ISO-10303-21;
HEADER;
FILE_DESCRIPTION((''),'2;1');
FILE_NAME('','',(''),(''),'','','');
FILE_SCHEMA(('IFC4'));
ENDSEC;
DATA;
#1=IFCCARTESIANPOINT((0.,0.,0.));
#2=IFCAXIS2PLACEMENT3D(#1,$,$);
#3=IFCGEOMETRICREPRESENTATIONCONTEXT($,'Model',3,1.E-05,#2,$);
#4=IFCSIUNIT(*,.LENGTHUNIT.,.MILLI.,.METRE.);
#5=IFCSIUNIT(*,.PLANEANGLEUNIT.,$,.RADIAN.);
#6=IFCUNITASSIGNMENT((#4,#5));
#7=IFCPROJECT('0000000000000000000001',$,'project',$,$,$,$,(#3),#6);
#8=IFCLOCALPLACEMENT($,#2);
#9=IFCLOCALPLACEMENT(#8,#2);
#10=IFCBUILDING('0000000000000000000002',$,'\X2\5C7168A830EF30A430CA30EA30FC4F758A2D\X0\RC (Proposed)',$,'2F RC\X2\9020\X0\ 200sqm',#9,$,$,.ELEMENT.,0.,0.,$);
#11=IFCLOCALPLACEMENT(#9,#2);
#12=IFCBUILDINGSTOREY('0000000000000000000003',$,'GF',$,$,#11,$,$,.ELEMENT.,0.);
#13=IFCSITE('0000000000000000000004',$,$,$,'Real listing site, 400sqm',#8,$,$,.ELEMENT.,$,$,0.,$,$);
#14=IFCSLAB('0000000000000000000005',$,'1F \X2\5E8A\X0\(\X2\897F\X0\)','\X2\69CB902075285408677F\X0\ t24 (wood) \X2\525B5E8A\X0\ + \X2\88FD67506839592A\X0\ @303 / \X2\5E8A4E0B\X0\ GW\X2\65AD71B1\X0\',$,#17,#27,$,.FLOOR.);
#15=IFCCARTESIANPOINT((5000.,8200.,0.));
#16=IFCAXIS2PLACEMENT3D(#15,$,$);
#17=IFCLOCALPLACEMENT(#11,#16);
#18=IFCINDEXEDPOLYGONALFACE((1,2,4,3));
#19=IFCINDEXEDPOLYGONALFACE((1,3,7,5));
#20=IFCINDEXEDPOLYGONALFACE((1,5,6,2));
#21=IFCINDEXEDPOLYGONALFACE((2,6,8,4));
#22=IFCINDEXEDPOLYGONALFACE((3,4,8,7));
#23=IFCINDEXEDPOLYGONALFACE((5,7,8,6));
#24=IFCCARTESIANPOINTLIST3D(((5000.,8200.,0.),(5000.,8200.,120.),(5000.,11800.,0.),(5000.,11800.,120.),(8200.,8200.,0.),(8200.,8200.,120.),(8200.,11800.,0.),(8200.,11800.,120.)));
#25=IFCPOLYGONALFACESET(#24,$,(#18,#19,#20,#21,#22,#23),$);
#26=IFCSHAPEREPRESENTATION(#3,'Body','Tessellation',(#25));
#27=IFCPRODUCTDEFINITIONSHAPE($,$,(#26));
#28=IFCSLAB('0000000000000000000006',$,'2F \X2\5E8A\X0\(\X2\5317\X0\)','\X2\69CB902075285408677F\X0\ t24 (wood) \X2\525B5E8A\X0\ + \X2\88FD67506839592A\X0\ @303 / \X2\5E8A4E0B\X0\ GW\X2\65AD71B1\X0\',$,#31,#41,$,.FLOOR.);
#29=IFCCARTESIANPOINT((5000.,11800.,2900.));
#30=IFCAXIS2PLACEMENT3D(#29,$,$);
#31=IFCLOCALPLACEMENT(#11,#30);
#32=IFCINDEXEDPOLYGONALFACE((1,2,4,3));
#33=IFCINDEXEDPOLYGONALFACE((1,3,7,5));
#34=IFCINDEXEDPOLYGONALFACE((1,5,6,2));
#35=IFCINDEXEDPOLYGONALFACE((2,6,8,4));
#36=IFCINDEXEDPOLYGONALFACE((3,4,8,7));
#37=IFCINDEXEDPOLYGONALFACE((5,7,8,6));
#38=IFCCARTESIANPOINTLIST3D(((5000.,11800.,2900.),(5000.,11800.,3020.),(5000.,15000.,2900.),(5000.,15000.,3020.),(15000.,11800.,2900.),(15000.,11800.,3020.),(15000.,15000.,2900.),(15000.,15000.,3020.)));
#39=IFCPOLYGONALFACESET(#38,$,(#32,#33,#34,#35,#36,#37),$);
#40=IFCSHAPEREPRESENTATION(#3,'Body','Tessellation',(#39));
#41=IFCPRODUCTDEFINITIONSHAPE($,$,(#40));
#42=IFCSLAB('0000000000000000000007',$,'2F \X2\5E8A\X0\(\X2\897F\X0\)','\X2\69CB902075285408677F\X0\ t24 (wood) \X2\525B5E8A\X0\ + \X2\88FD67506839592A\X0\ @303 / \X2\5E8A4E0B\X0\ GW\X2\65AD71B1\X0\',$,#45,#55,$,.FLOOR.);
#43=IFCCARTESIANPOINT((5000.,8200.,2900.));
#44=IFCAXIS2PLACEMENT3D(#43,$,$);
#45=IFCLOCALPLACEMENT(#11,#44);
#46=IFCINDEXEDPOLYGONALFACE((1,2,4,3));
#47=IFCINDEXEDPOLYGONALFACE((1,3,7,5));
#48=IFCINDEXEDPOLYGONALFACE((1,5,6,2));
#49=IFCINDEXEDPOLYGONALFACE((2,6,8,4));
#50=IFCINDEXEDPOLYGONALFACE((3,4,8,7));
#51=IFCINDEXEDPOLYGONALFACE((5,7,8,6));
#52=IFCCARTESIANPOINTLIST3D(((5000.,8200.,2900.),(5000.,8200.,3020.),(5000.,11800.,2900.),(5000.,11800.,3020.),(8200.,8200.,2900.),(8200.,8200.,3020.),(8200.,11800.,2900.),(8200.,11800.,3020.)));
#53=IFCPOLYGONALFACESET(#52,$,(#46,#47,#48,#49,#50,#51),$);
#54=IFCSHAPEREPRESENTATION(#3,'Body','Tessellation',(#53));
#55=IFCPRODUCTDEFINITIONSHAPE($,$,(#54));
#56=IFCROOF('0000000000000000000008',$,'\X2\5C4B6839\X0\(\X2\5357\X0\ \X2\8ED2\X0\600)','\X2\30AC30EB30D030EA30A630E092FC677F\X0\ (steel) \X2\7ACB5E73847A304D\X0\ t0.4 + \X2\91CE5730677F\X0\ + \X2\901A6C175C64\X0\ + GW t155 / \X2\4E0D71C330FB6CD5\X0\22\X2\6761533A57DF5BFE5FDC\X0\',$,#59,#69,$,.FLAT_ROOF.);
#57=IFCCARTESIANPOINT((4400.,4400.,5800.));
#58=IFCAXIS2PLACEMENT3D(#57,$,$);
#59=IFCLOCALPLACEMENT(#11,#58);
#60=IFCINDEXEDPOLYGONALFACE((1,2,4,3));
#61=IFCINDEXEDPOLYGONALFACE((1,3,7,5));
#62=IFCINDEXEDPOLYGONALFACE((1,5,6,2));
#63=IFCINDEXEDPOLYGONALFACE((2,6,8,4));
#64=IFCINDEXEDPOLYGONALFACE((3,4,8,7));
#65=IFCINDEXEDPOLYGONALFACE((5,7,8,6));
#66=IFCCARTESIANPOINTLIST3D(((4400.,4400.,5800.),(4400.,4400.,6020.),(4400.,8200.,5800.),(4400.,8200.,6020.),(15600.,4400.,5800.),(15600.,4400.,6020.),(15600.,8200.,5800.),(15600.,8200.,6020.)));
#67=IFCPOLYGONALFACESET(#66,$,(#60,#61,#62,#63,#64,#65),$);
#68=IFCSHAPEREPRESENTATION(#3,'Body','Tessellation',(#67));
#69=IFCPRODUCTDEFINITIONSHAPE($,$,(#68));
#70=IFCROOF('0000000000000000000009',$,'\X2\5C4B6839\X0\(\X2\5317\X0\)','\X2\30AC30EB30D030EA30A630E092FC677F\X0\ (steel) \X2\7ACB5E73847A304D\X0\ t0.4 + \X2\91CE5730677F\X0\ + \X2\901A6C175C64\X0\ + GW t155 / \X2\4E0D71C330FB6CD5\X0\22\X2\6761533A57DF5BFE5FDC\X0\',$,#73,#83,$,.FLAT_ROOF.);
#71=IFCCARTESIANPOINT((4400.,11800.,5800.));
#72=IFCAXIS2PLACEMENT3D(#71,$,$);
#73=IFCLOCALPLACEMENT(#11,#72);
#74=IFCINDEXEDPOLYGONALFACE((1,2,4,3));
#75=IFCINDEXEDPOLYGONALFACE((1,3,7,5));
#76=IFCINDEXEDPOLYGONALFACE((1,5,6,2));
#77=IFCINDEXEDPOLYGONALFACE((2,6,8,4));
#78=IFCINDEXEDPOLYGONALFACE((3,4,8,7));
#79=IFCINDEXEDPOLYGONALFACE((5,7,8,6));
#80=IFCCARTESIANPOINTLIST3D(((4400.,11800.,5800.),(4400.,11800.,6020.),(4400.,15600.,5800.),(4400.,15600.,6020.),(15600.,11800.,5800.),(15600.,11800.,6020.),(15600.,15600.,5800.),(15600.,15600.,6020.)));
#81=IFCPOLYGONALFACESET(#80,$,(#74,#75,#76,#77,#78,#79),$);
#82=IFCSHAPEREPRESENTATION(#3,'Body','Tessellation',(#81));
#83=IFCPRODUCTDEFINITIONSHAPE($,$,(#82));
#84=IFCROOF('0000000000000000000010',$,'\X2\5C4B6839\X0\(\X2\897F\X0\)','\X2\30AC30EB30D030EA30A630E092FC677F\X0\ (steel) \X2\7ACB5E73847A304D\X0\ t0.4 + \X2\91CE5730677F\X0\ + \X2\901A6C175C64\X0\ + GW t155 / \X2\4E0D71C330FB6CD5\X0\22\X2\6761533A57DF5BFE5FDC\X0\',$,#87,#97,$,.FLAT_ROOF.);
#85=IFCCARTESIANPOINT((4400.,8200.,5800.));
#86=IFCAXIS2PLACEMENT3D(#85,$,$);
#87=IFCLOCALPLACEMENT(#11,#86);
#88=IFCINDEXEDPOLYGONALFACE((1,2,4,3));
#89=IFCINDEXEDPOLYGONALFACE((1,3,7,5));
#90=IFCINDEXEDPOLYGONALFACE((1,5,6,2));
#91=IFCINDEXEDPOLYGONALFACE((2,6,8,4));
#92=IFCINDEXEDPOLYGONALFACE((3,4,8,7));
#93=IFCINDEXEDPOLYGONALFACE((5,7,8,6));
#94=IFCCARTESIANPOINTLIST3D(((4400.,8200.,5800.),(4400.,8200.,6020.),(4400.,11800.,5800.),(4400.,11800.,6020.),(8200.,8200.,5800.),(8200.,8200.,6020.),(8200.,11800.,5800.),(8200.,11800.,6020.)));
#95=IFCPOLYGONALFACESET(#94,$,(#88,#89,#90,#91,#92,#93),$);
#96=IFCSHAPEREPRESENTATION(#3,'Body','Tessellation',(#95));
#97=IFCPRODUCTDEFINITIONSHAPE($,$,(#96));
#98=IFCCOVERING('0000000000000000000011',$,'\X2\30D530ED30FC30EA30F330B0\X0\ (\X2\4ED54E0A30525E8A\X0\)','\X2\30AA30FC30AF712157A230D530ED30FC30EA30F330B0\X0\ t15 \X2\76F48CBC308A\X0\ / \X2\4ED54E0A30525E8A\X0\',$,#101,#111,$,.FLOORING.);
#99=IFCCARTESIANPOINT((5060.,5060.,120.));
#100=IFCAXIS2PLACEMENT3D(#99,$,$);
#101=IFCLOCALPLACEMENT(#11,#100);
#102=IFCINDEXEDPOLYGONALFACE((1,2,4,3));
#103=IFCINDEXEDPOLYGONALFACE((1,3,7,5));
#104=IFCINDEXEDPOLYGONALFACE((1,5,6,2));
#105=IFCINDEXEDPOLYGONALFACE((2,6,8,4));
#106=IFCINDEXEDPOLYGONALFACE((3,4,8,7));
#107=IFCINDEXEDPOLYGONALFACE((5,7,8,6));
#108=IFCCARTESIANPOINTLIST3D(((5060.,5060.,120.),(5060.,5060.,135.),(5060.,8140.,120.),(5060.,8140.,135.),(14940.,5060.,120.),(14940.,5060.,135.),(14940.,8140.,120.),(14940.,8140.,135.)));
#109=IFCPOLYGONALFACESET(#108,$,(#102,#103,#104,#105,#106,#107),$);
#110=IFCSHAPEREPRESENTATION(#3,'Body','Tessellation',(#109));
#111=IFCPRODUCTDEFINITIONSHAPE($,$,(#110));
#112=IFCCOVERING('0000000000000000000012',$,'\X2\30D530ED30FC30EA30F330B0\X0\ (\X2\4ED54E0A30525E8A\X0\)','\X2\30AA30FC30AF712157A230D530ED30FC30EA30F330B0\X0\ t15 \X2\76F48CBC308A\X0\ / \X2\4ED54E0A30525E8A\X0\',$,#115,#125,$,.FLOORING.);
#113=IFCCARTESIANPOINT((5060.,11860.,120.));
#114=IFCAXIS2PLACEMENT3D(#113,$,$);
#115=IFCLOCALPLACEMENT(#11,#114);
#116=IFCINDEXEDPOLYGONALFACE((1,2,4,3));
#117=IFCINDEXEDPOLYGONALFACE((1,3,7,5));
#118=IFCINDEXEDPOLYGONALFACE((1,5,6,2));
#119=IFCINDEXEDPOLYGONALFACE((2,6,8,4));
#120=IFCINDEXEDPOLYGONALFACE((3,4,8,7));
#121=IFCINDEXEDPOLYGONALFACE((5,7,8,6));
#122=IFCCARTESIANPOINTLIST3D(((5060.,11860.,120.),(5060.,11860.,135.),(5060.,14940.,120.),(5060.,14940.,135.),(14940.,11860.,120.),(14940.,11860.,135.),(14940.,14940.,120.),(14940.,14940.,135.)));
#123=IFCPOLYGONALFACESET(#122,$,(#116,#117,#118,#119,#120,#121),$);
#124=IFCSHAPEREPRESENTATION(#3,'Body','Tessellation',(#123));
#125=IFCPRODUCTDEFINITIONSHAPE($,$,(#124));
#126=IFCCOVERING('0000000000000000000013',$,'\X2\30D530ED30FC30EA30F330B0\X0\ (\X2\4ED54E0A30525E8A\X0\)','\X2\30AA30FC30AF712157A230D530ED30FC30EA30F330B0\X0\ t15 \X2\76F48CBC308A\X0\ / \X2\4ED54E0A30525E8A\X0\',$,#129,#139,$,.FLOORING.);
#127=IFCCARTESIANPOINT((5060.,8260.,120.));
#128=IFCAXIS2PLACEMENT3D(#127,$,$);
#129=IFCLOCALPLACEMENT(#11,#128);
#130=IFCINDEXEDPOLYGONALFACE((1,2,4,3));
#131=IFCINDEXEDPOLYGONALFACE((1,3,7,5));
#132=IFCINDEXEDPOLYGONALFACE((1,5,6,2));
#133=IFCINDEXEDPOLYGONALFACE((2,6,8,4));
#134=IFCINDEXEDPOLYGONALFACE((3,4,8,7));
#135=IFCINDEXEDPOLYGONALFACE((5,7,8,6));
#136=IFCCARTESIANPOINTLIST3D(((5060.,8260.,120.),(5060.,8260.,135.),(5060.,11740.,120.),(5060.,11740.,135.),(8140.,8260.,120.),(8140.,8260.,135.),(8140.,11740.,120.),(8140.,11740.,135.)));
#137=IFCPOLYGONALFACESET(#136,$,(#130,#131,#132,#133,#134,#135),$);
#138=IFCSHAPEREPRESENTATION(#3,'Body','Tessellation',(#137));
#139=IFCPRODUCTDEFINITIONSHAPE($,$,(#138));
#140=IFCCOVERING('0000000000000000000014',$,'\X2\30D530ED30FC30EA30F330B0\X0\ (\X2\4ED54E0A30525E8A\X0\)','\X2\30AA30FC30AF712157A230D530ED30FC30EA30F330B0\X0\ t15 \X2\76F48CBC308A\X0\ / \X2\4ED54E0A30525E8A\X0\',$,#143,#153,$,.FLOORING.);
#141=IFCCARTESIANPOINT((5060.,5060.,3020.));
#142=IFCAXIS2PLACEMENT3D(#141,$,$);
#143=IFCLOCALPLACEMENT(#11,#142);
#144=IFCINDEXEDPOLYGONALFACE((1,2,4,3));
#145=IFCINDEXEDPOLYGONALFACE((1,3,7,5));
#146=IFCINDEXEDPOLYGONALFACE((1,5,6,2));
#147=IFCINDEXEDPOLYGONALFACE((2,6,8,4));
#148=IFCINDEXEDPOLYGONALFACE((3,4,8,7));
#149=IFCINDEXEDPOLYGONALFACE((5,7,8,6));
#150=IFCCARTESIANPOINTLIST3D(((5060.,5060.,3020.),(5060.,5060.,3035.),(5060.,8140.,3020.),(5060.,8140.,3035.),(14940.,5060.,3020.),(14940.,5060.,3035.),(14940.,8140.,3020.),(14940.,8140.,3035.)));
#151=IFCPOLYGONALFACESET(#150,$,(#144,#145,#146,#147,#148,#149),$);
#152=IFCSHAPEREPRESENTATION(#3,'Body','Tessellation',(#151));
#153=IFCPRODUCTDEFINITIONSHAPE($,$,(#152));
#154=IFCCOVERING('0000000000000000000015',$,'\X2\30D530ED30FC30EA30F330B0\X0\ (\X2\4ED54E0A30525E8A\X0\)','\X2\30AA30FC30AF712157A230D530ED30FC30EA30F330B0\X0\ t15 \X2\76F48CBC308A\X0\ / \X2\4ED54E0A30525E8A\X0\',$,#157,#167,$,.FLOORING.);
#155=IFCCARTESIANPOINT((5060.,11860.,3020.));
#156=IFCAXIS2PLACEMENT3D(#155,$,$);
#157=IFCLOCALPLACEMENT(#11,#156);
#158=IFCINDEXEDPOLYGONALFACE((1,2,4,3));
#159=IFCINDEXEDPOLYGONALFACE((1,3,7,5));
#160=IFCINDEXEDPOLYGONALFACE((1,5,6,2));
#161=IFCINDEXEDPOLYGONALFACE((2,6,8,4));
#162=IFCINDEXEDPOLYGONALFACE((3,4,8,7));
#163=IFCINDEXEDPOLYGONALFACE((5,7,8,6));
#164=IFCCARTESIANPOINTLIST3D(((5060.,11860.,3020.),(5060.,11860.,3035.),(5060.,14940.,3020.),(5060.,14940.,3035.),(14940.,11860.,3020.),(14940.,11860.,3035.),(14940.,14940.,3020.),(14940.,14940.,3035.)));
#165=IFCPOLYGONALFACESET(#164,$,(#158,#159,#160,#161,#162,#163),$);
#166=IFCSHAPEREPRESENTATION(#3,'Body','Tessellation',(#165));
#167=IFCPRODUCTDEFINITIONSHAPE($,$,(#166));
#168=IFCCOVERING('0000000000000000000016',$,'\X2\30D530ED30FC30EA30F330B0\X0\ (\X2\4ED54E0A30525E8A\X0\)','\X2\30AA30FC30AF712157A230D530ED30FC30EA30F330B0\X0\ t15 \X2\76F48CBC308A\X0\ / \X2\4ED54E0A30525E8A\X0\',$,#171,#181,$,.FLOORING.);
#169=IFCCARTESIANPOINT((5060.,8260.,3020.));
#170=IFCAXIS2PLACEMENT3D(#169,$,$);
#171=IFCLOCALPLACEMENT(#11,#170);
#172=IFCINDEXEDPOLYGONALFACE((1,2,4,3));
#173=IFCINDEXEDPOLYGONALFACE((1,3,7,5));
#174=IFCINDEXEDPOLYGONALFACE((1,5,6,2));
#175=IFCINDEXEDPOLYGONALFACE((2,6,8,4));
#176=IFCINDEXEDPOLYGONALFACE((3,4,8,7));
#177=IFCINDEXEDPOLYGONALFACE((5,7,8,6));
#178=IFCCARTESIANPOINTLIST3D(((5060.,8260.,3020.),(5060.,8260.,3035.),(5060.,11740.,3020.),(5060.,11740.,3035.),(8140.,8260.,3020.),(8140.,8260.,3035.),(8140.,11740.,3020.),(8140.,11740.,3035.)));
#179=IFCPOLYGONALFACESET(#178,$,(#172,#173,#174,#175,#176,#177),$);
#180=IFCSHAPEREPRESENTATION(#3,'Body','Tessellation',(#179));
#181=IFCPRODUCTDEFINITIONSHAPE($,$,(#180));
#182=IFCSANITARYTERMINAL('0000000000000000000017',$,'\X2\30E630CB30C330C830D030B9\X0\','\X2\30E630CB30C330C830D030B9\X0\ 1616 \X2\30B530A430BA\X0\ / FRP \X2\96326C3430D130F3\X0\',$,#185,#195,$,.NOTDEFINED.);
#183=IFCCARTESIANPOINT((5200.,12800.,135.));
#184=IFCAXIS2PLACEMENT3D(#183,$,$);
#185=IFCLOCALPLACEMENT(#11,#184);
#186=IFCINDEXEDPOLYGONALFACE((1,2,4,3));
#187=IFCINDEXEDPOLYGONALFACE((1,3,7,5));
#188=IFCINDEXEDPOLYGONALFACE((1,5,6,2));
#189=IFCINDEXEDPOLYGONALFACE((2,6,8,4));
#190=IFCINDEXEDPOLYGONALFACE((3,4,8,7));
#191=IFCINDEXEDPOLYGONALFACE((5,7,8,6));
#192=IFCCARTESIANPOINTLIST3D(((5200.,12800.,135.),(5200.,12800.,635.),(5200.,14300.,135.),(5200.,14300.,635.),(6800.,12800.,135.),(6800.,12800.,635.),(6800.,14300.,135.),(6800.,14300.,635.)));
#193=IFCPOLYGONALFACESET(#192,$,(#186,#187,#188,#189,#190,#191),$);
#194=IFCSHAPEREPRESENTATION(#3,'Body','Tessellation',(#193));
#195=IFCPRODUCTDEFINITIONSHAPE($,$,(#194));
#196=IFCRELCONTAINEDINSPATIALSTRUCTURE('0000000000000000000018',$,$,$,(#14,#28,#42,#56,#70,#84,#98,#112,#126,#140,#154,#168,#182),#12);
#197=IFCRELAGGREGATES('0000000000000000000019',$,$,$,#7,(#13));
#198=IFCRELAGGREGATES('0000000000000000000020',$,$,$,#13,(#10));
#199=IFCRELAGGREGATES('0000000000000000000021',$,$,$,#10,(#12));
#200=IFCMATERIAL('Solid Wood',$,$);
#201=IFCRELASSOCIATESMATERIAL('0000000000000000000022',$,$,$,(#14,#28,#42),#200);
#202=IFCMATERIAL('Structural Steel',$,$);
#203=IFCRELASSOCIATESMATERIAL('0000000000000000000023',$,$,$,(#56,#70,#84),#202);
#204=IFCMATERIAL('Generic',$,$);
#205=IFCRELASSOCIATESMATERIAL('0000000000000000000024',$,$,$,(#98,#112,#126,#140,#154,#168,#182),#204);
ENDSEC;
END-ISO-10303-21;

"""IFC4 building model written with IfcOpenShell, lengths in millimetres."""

from ifc_helpers import new_model, si_unit, frame, frame_2d, origin, place, context, project, spatial, rectangle, extrude, material, element, save


model = new_model("IFC4")

# Units and contexts
model_context = context("Model", 3, precision=1e-05, world=origin())
ifc_project = project(units=[si_unit("LENGTHUNIT", "METRE", prefix="MILLI"), si_unit("PLANEANGLEUNIT", "RADIAN")], contexts=[model_context])

# Site, building, storey
site_placement = place(None, origin())
site = spatial("IfcSite", under=ifc_project, at=site_placement, ObjectType="Real listing site, 400sqm", CompositionType="ELEMENT", RefElevation=0.0)
building_placement = place(site_placement, origin())
building = spatial("IfcBuilding", under=site, at=building_placement, Name="山梨ワイナリー併設RC (Proposed)", ObjectType="2F RC造 200sqm", CompositionType="ELEMENT", ElevationOfRefHeight=0.0, ElevationOfTerrain=0.0)
storey_placement = place(building_placement, origin())
storey = spatial("IfcBuildingStorey", under=building, at=storey_placement, Name="GF", CompositionType="ELEMENT", Elevation=0.0)

# Slabs
ifc_material_1 = material(Name="Solid Wood")
slab_1_placement = place(storey_placement, frame((5000.0, 8200.0, 0.0)))
element("IfcSlab", 1, at=slab_1_placement, inside=storey, material=ifc_material_1, Name="1F 床(西)", Description="構造用合板 t24 (wood) 剛床 + 製材根太 @303 / 床下 GW断熱", PredefinedType="FLOOR", context=model_context, shape_type="SweptSolid", body=[
    extrude(rectangle(XDim=3200.0, YDim=3600.0, at=frame_2d((1600.0, 1800.0))), frame((5000.0, 8200.0, 0.0)), (0.0, 0.0, 1.0), 120.0),
])
slab_2_placement = place(storey_placement, frame((5000.0, 11800.0, 2900.0)))
element("IfcSlab", 2, at=slab_2_placement, inside=storey, material=ifc_material_1, Name="2F 床(北)", Description="構造用合板 t24 (wood) 剛床 + 製材根太 @303 / 床下 GW断熱", PredefinedType="FLOOR", context=model_context, shape_type="SweptSolid", body=[
    extrude(rectangle(XDim=10000.0, YDim=3200.0, at=frame_2d((5000.0, 1600.0))), frame((5000.0, 11800.0, 2900.0)), (0.0, 0.0, 1.0), 120.0),
])
slab_3_placement = place(storey_placement, frame((5000.0, 8200.0, 2900.0)))
element("IfcSlab", 3, at=slab_3_placement, inside=storey, material=ifc_material_1, Name="2F 床(西)", Description="構造用合板 t24 (wood) 剛床 + 製材根太 @303 / 床下 GW断熱", PredefinedType="FLOOR", context=model_context, shape_type="SweptSolid", body=[
    extrude(rectangle(XDim=3200.0, YDim=3600.0, at=frame_2d((1600.0, 1800.0))), frame((5000.0, 8200.0, 2900.0)), (0.0, 0.0, 1.0), 120.0),
])

# Roofs
ifc_material_2 = material(Name="Structural Steel")
roof_1_placement = place(storey_placement, frame((4400.0, 4400.0, 5800.0)))
element("IfcRoof", 4, at=roof_1_placement, inside=storey, material=ifc_material_2, Name="屋根(南 軒600)", Description="ガルバリウム鋼板 (steel) 立平葺き t0.4 + 野地板 + 通気層 + GW t155 / 不燃・法22条区域対応", PredefinedType="FLAT_ROOF", context=model_context, shape_type="SweptSolid", body=[
    extrude(rectangle(XDim=11200.0, YDim=3800.0, at=frame_2d((5600.0, 1900.0))), frame((4400.0, 4400.0, 5800.0)), (0.0, 0.0, 1.0), 220.0),
])
roof_2_placement = place(storey_placement, frame((4400.0, 11800.0, 5800.0)))
element("IfcRoof", 5, at=roof_2_placement, inside=storey, material=ifc_material_2, Name="屋根(北)", Description="ガルバリウム鋼板 (steel) 立平葺き t0.4 + 野地板 + 通気層 + GW t155 / 不燃・法22条区域対応", PredefinedType="FLAT_ROOF", context=model_context, shape_type="SweptSolid", body=[
    extrude(rectangle(XDim=11200.0, YDim=3800.0, at=frame_2d((5600.0, 1900.0))), frame((4400.0, 11800.0, 5800.0)), (0.0, 0.0, 1.0), 220.0),
])
roof_3_placement = place(storey_placement, frame((4400.0, 8200.0, 5800.0)))
element("IfcRoof", 6, at=roof_3_placement, inside=storey, material=ifc_material_2, Name="屋根(西)", Description="ガルバリウム鋼板 (steel) 立平葺き t0.4 + 野地板 + 通気層 + GW t155 / 不燃・法22条区域対応", PredefinedType="FLAT_ROOF", context=model_context, shape_type="SweptSolid", body=[
    extrude(rectangle(XDim=3800.0, YDim=3600.0, at=frame_2d((1900.0, 1800.0))), frame((4400.0, 8200.0, 5800.0)), (0.0, 0.0, 1.0), 220.0),
])

# Coverings
ifc_material_3 = material(Name="Generic")
covering_1_placement = place(storey_placement, frame((5060.0, 5060.0, 120.0)))
element("IfcCovering", 7, at=covering_1_placement, inside=storey, material=ifc_material_3, Name="フローリング (仕上げ床)", Description="オーク無垢フローリング t15 直貼り / 仕上げ床", PredefinedType="FLOORING", context=model_context, shape_type="SweptSolid", body=[
    extrude(rectangle(XDim=9880.0, YDim=3080.0, at=frame_2d((4940.0, 1540.0))), frame((5060.0, 5060.0, 120.0)), (0.0, 0.0, 1.0), 15.0),
])
covering_2_placement = place(storey_placement, frame((5060.0, 11860.0, 120.0)))
element("IfcCovering", 8, at=covering_2_placement, inside=storey, material=ifc_material_3, Name="フローリング (仕上げ床)", Description="オーク無垢フローリング t15 直貼り / 仕上げ床", PredefinedType="FLOORING", context=model_context, shape_type="SweptSolid", body=[
    extrude(rectangle(XDim=9880.0, YDim=3080.0, at=frame_2d((4940.0, 1540.0))), frame((5060.0, 11860.0, 120.0)), (0.0, 0.0, 1.0), 15.0),
])
covering_3_placement = place(storey_placement, frame((5060.0, 8260.0, 120.0)))
element("IfcCovering", 9, at=covering_3_placement, inside=storey, material=ifc_material_3, Name="フローリング (仕上げ床)", Description="オーク無垢フローリング t15 直貼り / 仕上げ床", PredefinedType="FLOORING", context=model_context, shape_type="SweptSolid", body=[
    extrude(rectangle(XDim=3080.0, YDim=3480.0, at=frame_2d((1540.0, 1740.0))), frame((5060.0, 8260.0, 120.0)), (0.0, 0.0, 1.0), 15.0),
])
covering_4_placement = place(storey_placement, frame((5060.0, 5060.0, 3020.0)))
element("IfcCovering", 10, at=covering_4_placement, inside=storey, material=ifc_material_3, Name="フローリング (仕上げ床)", Description="オーク無垢フローリング t15 直貼り / 仕上げ床", PredefinedType="FLOORING", context=model_context, shape_type="SweptSolid", body=[
    extrude(rectangle(XDim=9880.0, YDim=3080.0, at=frame_2d((4940.0, 1540.0))), frame((5060.0, 5060.0, 3020.0)), (0.0, 0.0, 1.0), 15.0),
])
covering_5_placement = place(storey_placement, frame((5060.0, 11860.0, 3020.0)))
element("IfcCovering", 11, at=covering_5_placement, inside=storey, material=ifc_material_3, Name="フローリング (仕上げ床)", Description="オーク無垢フローリング t15 直貼り / 仕上げ床", PredefinedType="FLOORING", context=model_context, shape_type="SweptSolid", body=[
    extrude(rectangle(XDim=9880.0, YDim=3080.0, at=frame_2d((4940.0, 1540.0))), frame((5060.0, 11860.0, 3020.0)), (0.0, 0.0, 1.0), 15.0),
])
covering_6_placement = place(storey_placement, frame((5060.0, 8260.0, 3020.0)))
element("IfcCovering", 12, at=covering_6_placement, inside=storey, material=ifc_material_3, Name="フローリング (仕上げ床)", Description="オーク無垢フローリング t15 直貼り / 仕上げ床", PredefinedType="FLOORING", context=model_context, shape_type="SweptSolid", body=[
    extrude(rectangle(XDim=3080.0, YDim=3480.0, at=frame_2d((1540.0, 1740.0))), frame((5060.0, 8260.0, 3020.0)), (0.0, 0.0, 1.0), 15.0),
])

# Sanitary terminal
sanitary_terminal_placement = place(storey_placement, frame((5200.0, 12800.0, 135.0)))
element("IfcSanitaryTerminal", 13, at=sanitary_terminal_placement, inside=storey, material=ifc_material_3, Name="ユニットバス", Description="ユニットバス 1616 サイズ / FRP 防水パン", PredefinedType="NOTDEFINED", context=model_context, shape_type="SweptSolid", body=[
    extrude(rectangle(XDim=1600.0, YDim=1500.0, at=frame_2d((800.0, 750.0))), frame((5200.0, 12800.0, 135.0)), (0.0, 0.0, 1.0), 500.0),
])

save(model, "model.ifc")
